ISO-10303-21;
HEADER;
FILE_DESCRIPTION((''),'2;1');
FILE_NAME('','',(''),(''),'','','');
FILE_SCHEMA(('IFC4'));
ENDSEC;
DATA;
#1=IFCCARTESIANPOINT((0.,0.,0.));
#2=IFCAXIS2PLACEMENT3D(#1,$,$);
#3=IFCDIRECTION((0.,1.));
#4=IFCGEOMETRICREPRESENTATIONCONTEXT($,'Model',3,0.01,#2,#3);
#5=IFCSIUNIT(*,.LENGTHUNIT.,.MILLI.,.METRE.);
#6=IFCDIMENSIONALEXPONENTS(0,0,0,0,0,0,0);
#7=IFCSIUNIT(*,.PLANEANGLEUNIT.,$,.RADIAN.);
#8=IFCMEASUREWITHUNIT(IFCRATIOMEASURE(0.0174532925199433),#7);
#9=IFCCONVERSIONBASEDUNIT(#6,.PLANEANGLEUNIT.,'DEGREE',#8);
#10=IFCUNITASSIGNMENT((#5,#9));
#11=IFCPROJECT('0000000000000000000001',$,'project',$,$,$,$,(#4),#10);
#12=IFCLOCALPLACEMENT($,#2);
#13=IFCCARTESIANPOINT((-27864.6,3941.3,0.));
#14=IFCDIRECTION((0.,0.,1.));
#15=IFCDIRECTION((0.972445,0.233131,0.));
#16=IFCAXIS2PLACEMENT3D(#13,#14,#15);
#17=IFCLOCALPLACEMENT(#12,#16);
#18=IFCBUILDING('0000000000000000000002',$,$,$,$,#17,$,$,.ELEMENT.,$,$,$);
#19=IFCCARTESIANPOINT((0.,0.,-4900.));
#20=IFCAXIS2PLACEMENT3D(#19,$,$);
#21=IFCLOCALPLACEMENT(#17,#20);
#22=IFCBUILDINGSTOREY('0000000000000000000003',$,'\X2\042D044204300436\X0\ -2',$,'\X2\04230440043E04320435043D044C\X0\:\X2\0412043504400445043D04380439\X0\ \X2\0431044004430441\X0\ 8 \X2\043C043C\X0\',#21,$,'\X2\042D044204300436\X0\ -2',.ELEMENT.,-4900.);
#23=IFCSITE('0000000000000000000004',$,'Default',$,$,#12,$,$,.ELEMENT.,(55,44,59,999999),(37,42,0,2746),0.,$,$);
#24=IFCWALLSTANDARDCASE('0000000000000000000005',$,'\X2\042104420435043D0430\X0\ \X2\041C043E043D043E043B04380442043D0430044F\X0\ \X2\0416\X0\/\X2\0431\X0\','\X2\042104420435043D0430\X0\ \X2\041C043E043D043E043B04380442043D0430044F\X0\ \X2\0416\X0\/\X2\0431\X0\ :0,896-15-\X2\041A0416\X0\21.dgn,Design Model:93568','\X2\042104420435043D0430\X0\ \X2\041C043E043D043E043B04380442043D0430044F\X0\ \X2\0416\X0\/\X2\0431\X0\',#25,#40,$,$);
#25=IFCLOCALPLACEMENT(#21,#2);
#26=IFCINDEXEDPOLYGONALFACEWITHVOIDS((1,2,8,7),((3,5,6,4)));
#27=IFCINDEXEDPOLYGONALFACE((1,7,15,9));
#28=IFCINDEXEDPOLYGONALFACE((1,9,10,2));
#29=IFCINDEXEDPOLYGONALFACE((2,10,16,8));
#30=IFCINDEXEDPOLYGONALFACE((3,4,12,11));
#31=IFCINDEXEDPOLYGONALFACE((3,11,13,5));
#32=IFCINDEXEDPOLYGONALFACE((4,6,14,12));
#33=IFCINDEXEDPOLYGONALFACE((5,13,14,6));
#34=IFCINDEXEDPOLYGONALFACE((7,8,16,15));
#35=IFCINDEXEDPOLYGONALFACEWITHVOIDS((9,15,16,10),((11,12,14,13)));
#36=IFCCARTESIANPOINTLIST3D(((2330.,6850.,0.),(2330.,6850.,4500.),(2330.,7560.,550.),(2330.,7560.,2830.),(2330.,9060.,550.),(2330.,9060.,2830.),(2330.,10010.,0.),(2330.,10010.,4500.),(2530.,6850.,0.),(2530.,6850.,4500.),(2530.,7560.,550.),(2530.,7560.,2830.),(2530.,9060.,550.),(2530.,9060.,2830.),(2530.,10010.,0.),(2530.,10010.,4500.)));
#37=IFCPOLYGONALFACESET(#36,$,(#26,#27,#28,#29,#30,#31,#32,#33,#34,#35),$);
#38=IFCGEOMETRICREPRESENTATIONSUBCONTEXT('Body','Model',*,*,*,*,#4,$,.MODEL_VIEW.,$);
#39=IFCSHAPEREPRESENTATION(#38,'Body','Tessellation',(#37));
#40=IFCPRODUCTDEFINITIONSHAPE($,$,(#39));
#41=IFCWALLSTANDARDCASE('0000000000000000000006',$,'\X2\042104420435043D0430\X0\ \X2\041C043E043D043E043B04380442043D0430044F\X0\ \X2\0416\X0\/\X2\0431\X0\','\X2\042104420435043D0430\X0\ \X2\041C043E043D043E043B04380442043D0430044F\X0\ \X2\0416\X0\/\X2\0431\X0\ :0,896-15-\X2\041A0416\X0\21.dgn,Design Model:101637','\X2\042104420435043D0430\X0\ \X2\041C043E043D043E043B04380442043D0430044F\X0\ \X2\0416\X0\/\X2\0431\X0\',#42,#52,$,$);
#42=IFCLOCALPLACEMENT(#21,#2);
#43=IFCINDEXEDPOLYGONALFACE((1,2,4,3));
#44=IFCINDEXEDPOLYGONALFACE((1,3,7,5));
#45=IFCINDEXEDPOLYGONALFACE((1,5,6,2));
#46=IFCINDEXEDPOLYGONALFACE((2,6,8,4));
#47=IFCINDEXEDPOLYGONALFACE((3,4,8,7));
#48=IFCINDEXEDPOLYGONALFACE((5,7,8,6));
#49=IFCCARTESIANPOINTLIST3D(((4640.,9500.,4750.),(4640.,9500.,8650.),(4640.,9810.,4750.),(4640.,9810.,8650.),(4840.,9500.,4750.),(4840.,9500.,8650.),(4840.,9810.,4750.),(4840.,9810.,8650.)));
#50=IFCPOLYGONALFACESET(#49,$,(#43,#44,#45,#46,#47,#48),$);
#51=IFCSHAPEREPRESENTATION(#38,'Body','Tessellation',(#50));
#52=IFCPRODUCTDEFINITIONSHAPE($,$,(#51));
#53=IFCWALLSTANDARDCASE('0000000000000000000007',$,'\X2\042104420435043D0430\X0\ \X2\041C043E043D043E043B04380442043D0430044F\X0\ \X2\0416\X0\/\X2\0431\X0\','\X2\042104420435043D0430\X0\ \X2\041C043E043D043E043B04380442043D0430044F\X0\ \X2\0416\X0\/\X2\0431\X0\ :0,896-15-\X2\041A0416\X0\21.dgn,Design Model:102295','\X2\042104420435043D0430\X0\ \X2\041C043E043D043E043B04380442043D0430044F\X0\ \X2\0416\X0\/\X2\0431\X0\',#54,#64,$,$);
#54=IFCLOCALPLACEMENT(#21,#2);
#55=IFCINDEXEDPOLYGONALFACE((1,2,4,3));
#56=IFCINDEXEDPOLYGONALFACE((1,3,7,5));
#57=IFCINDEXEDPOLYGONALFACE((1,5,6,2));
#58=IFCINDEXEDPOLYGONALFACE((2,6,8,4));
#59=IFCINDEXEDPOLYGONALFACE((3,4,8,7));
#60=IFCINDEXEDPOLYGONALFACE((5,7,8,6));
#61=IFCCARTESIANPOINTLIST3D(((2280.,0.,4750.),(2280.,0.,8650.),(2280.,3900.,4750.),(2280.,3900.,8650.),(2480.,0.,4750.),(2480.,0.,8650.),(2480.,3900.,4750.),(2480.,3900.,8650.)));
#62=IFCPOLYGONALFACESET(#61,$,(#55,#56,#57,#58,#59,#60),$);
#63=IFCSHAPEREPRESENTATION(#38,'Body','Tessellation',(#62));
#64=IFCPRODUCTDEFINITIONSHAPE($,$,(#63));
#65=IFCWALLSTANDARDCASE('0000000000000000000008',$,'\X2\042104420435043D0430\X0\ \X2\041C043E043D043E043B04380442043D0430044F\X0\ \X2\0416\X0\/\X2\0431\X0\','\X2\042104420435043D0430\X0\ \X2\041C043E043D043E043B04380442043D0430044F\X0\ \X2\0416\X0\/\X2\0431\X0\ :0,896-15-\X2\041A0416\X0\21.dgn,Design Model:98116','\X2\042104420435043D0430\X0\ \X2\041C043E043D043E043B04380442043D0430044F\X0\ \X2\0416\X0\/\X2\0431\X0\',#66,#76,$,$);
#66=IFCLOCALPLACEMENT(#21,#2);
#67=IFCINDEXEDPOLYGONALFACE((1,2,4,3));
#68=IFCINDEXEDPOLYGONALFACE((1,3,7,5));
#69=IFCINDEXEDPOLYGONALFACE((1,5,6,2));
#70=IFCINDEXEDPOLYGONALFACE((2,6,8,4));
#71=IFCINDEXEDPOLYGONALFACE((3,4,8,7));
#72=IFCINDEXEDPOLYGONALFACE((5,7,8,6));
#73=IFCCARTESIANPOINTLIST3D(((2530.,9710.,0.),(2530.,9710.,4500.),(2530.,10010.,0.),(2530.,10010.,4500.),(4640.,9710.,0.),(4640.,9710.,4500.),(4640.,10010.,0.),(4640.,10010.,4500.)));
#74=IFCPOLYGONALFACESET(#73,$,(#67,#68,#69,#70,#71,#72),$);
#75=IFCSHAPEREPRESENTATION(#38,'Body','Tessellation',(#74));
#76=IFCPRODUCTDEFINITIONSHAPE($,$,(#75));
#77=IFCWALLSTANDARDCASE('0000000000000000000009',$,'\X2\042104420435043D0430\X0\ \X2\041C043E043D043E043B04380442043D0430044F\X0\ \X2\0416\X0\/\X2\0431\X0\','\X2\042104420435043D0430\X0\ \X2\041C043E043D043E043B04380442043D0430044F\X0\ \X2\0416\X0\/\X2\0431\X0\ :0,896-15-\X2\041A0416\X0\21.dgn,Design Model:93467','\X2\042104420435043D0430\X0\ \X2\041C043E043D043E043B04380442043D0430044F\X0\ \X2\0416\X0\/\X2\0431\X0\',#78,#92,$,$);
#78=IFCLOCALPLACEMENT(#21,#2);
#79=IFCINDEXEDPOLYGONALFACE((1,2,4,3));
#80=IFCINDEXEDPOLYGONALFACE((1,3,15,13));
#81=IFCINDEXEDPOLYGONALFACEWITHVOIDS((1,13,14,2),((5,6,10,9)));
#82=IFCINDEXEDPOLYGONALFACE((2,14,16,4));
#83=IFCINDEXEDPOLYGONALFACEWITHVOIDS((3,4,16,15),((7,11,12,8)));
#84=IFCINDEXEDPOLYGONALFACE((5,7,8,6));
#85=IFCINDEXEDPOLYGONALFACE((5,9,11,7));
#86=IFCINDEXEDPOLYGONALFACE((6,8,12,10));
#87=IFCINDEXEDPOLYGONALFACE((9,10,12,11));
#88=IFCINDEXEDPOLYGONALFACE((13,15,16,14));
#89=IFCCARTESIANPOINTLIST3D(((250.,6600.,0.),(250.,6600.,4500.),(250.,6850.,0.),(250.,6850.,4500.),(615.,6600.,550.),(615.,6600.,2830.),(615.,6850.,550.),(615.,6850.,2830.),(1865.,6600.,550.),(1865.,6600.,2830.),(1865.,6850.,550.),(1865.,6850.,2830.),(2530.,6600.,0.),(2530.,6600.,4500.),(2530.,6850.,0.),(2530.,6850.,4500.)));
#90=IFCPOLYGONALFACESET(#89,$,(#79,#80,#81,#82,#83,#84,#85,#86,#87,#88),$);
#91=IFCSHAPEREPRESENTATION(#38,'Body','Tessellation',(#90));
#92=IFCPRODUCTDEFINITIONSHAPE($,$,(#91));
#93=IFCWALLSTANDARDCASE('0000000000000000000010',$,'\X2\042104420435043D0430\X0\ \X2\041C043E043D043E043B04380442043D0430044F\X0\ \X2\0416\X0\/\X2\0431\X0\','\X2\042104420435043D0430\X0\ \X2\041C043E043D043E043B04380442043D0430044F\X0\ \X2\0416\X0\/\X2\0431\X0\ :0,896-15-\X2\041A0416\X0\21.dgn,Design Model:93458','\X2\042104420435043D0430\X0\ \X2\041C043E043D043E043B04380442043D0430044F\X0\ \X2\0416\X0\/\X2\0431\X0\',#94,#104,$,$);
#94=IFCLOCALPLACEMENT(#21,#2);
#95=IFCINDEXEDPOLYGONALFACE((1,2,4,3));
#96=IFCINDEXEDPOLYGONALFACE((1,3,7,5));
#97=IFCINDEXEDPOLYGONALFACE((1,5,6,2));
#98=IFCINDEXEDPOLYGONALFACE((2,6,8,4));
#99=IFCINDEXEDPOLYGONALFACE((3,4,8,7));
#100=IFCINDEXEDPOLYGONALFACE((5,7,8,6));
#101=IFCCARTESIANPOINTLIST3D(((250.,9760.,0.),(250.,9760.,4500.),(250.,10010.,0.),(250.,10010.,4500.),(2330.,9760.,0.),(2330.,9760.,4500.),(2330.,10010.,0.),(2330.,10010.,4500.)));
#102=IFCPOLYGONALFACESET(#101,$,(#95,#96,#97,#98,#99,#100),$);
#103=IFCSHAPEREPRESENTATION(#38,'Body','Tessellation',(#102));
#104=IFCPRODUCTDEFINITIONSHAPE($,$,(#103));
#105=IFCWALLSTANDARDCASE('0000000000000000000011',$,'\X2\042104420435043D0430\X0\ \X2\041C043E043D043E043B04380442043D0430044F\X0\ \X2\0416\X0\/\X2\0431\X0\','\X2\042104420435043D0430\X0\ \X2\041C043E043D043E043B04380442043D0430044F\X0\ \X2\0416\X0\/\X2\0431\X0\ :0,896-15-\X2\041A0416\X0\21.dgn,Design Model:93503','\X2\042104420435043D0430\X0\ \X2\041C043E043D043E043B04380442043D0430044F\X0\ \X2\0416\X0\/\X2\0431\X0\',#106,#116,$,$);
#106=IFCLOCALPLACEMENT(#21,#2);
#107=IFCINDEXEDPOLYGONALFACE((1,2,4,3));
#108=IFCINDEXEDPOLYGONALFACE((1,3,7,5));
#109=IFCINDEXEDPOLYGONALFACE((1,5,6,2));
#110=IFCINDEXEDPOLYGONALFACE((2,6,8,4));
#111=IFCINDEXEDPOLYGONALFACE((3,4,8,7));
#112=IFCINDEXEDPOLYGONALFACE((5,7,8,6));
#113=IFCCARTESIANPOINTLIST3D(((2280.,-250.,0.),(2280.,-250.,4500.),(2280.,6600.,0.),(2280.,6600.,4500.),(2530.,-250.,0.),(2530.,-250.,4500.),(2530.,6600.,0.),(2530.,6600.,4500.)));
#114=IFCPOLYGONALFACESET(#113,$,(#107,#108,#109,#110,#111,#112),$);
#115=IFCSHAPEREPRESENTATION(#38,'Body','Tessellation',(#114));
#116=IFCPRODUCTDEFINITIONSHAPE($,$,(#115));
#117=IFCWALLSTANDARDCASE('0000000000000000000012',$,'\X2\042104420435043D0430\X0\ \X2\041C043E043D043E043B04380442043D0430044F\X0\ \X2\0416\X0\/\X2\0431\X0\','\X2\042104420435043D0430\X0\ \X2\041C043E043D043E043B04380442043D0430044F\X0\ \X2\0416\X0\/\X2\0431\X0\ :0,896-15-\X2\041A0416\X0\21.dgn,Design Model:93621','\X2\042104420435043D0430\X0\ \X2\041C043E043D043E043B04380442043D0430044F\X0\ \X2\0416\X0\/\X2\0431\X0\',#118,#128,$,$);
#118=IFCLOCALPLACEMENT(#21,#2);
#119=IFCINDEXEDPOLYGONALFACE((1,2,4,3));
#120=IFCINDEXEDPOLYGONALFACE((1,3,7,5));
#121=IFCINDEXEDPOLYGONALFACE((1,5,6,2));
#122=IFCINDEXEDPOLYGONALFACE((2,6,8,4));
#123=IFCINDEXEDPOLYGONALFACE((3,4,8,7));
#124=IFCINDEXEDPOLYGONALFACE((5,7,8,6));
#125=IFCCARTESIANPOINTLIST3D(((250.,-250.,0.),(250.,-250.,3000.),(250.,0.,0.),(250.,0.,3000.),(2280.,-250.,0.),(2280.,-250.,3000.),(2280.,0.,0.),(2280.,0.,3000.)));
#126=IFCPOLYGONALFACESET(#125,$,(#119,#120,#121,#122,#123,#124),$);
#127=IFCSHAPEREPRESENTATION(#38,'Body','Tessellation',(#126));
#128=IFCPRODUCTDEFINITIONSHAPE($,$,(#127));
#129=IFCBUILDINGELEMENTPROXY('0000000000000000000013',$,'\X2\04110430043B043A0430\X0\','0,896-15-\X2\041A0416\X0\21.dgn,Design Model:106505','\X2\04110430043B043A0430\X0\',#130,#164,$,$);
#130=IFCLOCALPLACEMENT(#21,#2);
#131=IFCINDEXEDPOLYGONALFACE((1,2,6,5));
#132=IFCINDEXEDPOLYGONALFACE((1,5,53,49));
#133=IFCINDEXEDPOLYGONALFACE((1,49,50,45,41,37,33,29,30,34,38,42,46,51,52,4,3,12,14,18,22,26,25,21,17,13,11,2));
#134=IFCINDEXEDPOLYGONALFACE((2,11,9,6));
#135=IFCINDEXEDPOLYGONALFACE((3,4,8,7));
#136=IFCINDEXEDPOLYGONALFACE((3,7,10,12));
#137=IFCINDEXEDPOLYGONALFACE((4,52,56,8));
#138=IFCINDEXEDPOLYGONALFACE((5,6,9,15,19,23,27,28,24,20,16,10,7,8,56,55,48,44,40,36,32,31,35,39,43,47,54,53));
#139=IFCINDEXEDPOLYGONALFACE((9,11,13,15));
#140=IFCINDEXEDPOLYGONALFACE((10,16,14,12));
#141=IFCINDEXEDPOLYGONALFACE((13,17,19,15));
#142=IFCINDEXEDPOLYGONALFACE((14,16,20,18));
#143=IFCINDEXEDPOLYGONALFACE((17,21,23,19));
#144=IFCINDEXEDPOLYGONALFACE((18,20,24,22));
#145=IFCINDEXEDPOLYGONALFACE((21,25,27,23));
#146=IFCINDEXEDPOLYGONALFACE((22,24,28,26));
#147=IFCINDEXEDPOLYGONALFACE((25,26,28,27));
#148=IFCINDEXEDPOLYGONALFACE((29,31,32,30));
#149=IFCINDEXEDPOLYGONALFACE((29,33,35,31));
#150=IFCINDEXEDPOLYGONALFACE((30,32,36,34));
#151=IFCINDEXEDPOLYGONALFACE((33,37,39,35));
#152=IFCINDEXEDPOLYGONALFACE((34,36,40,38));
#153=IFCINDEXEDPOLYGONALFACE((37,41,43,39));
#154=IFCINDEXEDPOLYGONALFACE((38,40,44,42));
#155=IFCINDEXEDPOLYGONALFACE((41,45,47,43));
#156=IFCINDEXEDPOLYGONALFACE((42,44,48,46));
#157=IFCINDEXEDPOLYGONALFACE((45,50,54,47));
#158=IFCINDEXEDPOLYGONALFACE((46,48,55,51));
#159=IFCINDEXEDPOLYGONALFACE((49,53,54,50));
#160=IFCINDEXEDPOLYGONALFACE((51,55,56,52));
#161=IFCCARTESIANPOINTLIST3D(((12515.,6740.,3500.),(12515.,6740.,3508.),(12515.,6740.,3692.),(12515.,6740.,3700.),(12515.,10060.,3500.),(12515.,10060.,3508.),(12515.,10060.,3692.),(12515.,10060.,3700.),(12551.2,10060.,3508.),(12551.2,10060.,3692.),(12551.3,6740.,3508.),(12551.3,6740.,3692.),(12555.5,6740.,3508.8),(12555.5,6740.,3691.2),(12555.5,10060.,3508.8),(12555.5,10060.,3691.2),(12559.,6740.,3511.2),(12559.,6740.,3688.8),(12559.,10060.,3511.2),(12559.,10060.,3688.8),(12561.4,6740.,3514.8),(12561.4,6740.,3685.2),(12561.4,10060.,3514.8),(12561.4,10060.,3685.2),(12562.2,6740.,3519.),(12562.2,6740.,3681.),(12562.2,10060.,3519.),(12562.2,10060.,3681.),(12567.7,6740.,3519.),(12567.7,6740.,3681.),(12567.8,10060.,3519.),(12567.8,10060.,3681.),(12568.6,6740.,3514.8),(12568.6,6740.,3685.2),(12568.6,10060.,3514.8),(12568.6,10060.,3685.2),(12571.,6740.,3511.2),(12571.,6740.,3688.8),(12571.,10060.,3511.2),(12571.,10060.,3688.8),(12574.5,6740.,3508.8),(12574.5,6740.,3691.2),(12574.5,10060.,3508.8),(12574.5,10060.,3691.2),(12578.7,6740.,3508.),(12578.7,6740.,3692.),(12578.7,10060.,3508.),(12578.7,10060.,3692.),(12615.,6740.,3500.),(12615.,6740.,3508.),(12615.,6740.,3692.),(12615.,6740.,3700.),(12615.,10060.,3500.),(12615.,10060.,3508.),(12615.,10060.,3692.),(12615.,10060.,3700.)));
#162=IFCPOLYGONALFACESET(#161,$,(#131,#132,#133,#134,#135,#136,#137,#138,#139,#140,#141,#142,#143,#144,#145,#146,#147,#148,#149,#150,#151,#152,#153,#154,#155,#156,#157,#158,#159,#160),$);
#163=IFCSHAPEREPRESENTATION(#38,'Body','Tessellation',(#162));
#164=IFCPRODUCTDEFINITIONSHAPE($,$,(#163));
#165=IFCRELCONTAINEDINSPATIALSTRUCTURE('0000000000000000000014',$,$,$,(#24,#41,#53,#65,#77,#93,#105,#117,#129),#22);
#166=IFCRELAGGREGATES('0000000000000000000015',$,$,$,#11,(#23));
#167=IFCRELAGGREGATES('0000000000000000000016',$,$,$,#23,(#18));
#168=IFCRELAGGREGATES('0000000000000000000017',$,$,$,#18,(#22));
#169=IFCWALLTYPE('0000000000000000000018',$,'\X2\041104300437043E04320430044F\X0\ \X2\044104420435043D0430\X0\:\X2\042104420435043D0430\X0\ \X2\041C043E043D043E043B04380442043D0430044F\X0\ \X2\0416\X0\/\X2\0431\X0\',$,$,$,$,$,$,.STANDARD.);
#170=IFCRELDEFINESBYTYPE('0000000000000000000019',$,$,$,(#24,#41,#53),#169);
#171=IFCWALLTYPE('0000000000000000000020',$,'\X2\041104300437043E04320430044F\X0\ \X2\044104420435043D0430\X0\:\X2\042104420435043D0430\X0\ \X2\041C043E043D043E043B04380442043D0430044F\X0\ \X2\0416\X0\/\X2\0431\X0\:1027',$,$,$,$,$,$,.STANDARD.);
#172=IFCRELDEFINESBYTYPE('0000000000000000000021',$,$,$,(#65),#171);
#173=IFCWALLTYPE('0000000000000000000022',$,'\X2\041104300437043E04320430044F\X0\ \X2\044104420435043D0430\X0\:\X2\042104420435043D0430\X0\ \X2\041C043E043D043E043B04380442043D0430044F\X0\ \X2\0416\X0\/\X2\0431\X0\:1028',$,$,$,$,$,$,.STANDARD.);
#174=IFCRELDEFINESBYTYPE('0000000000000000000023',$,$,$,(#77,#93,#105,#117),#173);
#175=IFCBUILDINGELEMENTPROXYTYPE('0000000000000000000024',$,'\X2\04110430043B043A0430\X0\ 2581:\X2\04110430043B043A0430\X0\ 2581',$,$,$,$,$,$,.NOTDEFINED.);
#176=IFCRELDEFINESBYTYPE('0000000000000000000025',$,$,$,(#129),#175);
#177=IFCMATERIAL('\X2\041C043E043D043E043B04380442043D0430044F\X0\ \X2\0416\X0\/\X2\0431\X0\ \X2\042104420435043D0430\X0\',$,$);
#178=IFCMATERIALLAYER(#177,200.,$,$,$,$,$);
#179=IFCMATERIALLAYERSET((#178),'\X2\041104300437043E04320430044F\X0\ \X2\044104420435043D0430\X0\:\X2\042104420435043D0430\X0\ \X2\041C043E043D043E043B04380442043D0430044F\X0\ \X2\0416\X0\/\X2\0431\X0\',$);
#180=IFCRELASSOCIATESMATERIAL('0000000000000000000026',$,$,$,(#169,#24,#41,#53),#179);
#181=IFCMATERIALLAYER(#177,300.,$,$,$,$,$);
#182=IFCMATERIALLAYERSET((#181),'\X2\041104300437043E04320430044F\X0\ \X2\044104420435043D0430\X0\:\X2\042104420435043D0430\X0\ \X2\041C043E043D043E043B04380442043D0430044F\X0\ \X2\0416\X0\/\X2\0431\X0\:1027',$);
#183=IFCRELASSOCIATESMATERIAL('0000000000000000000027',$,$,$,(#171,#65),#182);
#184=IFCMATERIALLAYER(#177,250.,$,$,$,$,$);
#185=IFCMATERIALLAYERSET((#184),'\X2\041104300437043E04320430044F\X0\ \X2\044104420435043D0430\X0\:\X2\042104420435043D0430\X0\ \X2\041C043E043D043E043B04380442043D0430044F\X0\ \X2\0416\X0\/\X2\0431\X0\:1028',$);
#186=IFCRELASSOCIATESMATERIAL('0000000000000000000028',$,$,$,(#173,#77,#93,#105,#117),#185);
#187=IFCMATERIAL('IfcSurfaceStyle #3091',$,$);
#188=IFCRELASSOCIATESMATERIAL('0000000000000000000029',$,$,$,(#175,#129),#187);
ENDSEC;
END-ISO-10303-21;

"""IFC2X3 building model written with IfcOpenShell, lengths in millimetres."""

from ifc_helpers import new_model, entity, si_unit, converted_unit, direction, frame, frame_2d, origin, origin_2d_with_axis, place, context, subcontext, project, spatial, polyline, rectangle, outline, extrude, source, transform, mapped, material, layer, layer_set, layer_usage, type_object, type_shapes, element, save


model = new_model("IFC2X3")

# Units and contexts
model_context = context("Model", 3, precision=0.01, world=origin(), true_north=direction((0.0, 1.0)))
body_context = subcontext(model_context, "Body", "Model", "MODEL_VIEW")
ifc_project = project(units=[si_unit("LENGTHUNIT", "METRE", prefix="MILLI"), converted_unit("PLANEANGLEUNIT", "DEGREE", entity("IfcRatioMeasure", 0.0174532925199433), si_unit("PLANEANGLEUNIT", "RADIAN"), dimensions=[0, 0, 0, 0, 0, 0, 0])], contexts=[model_context])

# Site, building, storey
site_placement = place(None, origin())
site = spatial("IfcSite", under=ifc_project, at=site_placement, Name="Default", CompositionType="ELEMENT", RefLatitude=(55, 44, 59, 999999), RefLongitude=(37, 42, 0, 2746), RefElevation=0.0)
building_placement = place(site_placement, frame((-27864.6, 3941.3, 0.0), z_axis=(0.0, 0.0, 1.0), x_axis=(0.972445, 0.233131, 0.0)))
building = spatial("IfcBuilding", under=site, at=building_placement, CompositionType="ELEMENT")
storey_placement = place(building_placement, frame((0.0, 0.0, -4900.0)))
storey = spatial("IfcBuildingStorey", under=building, at=storey_placement, Name="Этаж -2", ObjectType="Уровень:Верхний брус 8 мм", LongName="Этаж -2", CompositionType="ELEMENT", Elevation=-4900.0)

# Wall, opening
ifc_material_1 = material(Name="Монолитная Ж/б Стена")
ifc_layer_1 = layer(ifc_material_1, 200.0)
ifc_layer_set_1 = layer_set([ifc_layer_1], Name="Базовая стена:Стена Монолитная Ж/б")
ifc_layer_usage_1 = layer_usage(ifc_layer_set_1, "AXIS2", "NEGATIVE", 100.0)
wall_type_1 = type_object("IfcWallType", Name="Базовая стена:Стена Монолитная Ж/б", PredefinedType="STANDARD", material=ifc_layer_set_1)
wall_1_placement = place(storey_placement, frame((2430.0, 6850.0, 0.0), z_axis=(0.0, 0.0, 1.0), x_axis=(0.0, 1.0, 0.0)))
wall_1 = element("IfcWallStandardCase", 1, at=wall_1_placement, inside=storey, type_object=wall_type_1, material=ifc_layer_usage_1, Name="Стена Монолитная Ж/б", Description="Стена Монолитная Ж/б :0,896-15-КЖ21.dgn,Design Model:93568", ObjectType="Стена Монолитная Ж/б", context=body_context, shape_type="SweptSolid", body=[
    extrude(rectangle(XDim=3160.0, YDim=200.0, at=frame_2d((1580.0, 0.0), x_axis=(-1.0, 0.0))), origin(), (0.0, 0.0, 1.0), 4500.0),
])
opening_1_placement = place(wall_1_placement, origin())
element("IfcOpeningElement", 2, at=opening_1_placement, cuts=wall_1, ObjectType="Opening", context=body_context, shape_type="SweptSolid", body=[
    extrude(rectangle(XDim=2280.0, YDim=1500.0, at=origin_2d_with_axis()), frame((1460.0, -100.0, 1690.0), z_axis=(0.0, 1.0, 0.0), x_axis=(0.0, 0.0, -1.0)), (0.0, 0.0, 1.0), 200.0),
])

# Walls
wall_2_placement = place(storey_placement, frame((4740.0, 9500.0, 4750.0), z_axis=(0.0, 0.0, 1.0), x_axis=(0.0, 1.0, 0.0)))
element("IfcWallStandardCase", 3, at=wall_2_placement, inside=storey, type_object=wall_type_1, material=ifc_layer_usage_1, Name="Стена Монолитная Ж/б", Description="Стена Монолитная Ж/б :0,896-15-КЖ21.dgn,Design Model:101637", ObjectType="Стена Монолитная Ж/б", context=body_context, shape_type="SweptSolid", body=[
    extrude(rectangle(XDim=310.0, YDim=200.0, at=frame_2d((155.0, 0.0), x_axis=(-1.0, 0.0))), origin(), (0.0, 0.0, 1.0), 3900.0),
])
wall_3_placement = place(storey_placement, frame((2380.0, 3900.0, 4750.0), z_axis=(0.0, 0.0, 1.0), x_axis=(0.0, -1.0, 0.0)))
element("IfcWallStandardCase", 4, at=wall_3_placement, inside=storey, type_object=wall_type_1, material=ifc_layer_usage_1, Name="Стена Монолитная Ж/б", Description="Стена Монолитная Ж/б :0,896-15-КЖ21.dgn,Design Model:102295", ObjectType="Стена Монолитная Ж/б", context=body_context, shape_type="SweptSolid", body=[
    extrude(rectangle(XDim=3900.0, YDim=200.0, at=frame_2d((1950.0, 0.0), x_axis=(-1.0, 0.0))), origin(), (0.0, 0.0, 1.0), 3900.0),
])
ifc_layer_2 = layer(ifc_material_1, 300.0)
ifc_layer_set_2 = layer_set([ifc_layer_2], Name="Базовая стена:Стена Монолитная Ж/б:1027")
ifc_layer_usage_2 = layer_usage(ifc_layer_set_2, "AXIS2", "NEGATIVE", 150.0)
wall_type_2 = type_object("IfcWallType", Name="Базовая стена:Стена Монолитная Ж/б:1027", PredefinedType="STANDARD", material=ifc_layer_set_2)
wall_4_placement = place(storey_placement, frame((4640.0, 9860.0, 0.0), z_axis=(0.0, 0.0, 1.0), x_axis=(-1.0, 0.0, 0.0)))
element("IfcWallStandardCase", 5, at=wall_4_placement, inside=storey, type_object=wall_type_2, material=ifc_layer_usage_2, Name="Стена Монолитная Ж/б", Description="Стена Монолитная Ж/б :0,896-15-КЖ21.dgn,Design Model:98116", ObjectType="Стена Монолитная Ж/б", context=body_context, shape_type="SweptSolid", body=[
    extrude(rectangle(XDim=2110.0, YDim=300.0, at=frame_2d((1055.0, 0.0), x_axis=(-1.0, 0.0))), origin(), (0.0, 0.0, 1.0), 4500.0),
])

# Wall, opening
ifc_layer_3 = layer(ifc_material_1, 250.0)
ifc_layer_set_3 = layer_set([ifc_layer_3], Name="Базовая стена:Стена Монолитная Ж/б:1028")
ifc_layer_usage_3 = layer_usage(ifc_layer_set_3, "AXIS2", "NEGATIVE", 125.0)
wall_type_3 = type_object("IfcWallType", Name="Базовая стена:Стена Монолитная Ж/б:1028", PredefinedType="STANDARD", material=ifc_layer_set_3)
wall_5_placement = place(storey_placement, frame((2530.0, 6725.0, 0.0), z_axis=(0.0, 0.0, 1.0), x_axis=(-1.0, 0.0, 0.0)))
wall_5 = element("IfcWallStandardCase", 6, at=wall_5_placement, inside=storey, type_object=wall_type_3, material=ifc_layer_usage_3, Name="Стена Монолитная Ж/б", Description="Стена Монолитная Ж/б :0,896-15-КЖ21.dgn,Design Model:93467", ObjectType="Стена Монолитная Ж/б", context=body_context, shape_type="SweptSolid", body=[
    extrude(rectangle(XDim=2280.0, YDim=250.0, at=frame_2d((1140.0, 0.0), x_axis=(-1.0, 0.0))), origin(), (0.0, 0.0, 1.0), 4500.0),
])
opening_2_placement = place(wall_5_placement, origin())
element("IfcOpeningElement", 7, at=opening_2_placement, cuts=wall_5, ObjectType="Opening", context=body_context, shape_type="SweptSolid", body=[
    extrude(rectangle(XDim=2280.0, YDim=1250.0, at=origin_2d_with_axis()), frame((1290.0, -125.0, 1690.0), z_axis=(0.0, 1.0, 0.0), x_axis=(0.0, 0.0, -1.0)), (0.0, 0.0, 1.0), 250.0),
])

# Walls
wall_6_placement = place(storey_placement, frame((250.0, 9885.0, 0.0)))
element("IfcWallStandardCase", 8, at=wall_6_placement, inside=storey, type_object=wall_type_3, material=ifc_layer_usage_3, Name="Стена Монолитная Ж/б", Description="Стена Монолитная Ж/б :0,896-15-КЖ21.dgn,Design Model:93458", ObjectType="Стена Монолитная Ж/б", context=body_context, shape_type="SweptSolid", body=[
    extrude(rectangle(XDim=2080.0, YDim=250.0, at=frame_2d((1040.0, 0.0), x_axis=(-1.0, 0.0))), origin(), (0.0, 0.0, 1.0), 4500.0),
])
wall_7_placement = place(storey_placement, frame((2405.0, 6600.0, 0.0), z_axis=(0.0, 0.0, 1.0), x_axis=(0.0, -1.0, 0.0)))
element("IfcWallStandardCase", 9, at=wall_7_placement, inside=storey, type_object=wall_type_3, material=ifc_layer_usage_3, Name="Стена Монолитная Ж/б", Description="Стена Монолитная Ж/б :0,896-15-КЖ21.dgn,Design Model:93503", ObjectType="Стена Монолитная Ж/б", context=body_context, shape_type="SweptSolid", body=[
    extrude(rectangle(XDim=6850.0, YDim=250.0, at=frame_2d((3425.0, 0.0), x_axis=(-1.0, 0.0))), origin(), (0.0, 0.0, 1.0), 4500.0),
])
wall_8_placement = place(storey_placement, frame((2280.0, -125.0, 0.0), z_axis=(0.0, 0.0, 1.0), x_axis=(-1.0, 0.0, 0.0)))
element("IfcWallStandardCase", 10, at=wall_8_placement, inside=storey, type_object=wall_type_3, material=ifc_layer_usage_3, Name="Стена Монолитная Ж/б", Description="Стена Монолитная Ж/б :0,896-15-КЖ21.dgn,Design Model:93621", ObjectType="Стена Монолитная Ж/б", context=body_context, shape_type="SweptSolid", body=[
    extrude(rectangle(XDim=2030.0, YDim=250.0, at=frame_2d((1015.0, 0.0), x_axis=(-1.0, 0.0))), origin(), (0.0, 0.0, 1.0), 3000.0),
])

# Building element proxy
placement = place(storey_placement, frame((0.0, 0.0, 4900.0)))
ifc_material_2 = material(Name="IfcSurfaceStyle #3091")
building_element_proxy_type_1 = type_object("IfcBuildingElementProxyType", Name="Балка 2581:Балка 2581", PredefinedType="NOTDEFINED", material=ifc_material_2)
shared_shape_1 = source(origin(), body_context, "Body", "SweptSolid", [
    extrude(outline(polyline([(92.0, -50.0), (100.0, -50.0), (100.0, 50.0), (92.0, 50.0), (92.0, 13.8), (91.2, 9.5), (88.8, 6.0), (85.2, 3.6), (81.0, 2.8), (-81.0, 2.8), (-85.2, 3.6), (-88.8, 6.0), (-91.2, 9.5), (-92.0, 13.8), (-92.0, 50.0), (-100.0, 50.0), (-100.0, -50.0), (-92.0, -50.0), (-92.0, -13.8), (-91.2, -9.5), (-88.8, -6.0), (-85.2, -3.6), (-81.0, -2.8), (81.0, -2.8), (85.2, -3.6), (88.8, -6.0), (91.2, -9.5), (92.0, -13.8), (92.0, -50.0)])), frame((12565.0, 6740.0, -1300.0), z_axis=(0.0, 1.0, 0.0), x_axis=(0.0, 0.0, -1.0)), (0.0, 0.0, 1.0), 3320.0),
])
type_shapes(building_element_proxy_type_1, [shared_shape_1])
element("IfcBuildingElementProxy", 11, at=placement, inside=storey, type_object=building_element_proxy_type_1, material=ifc_material_2, Name="Балка", Description="0,896-15-КЖ21.dgn,Design Model:106505", ObjectType="Балка", context=body_context, shape_type="MappedRepresentation", body=[
    mapped(shared_shape_1, transform((0.0, 0.0, 0.0), scale=1.0)),
])

save(model, "model.ifc")
